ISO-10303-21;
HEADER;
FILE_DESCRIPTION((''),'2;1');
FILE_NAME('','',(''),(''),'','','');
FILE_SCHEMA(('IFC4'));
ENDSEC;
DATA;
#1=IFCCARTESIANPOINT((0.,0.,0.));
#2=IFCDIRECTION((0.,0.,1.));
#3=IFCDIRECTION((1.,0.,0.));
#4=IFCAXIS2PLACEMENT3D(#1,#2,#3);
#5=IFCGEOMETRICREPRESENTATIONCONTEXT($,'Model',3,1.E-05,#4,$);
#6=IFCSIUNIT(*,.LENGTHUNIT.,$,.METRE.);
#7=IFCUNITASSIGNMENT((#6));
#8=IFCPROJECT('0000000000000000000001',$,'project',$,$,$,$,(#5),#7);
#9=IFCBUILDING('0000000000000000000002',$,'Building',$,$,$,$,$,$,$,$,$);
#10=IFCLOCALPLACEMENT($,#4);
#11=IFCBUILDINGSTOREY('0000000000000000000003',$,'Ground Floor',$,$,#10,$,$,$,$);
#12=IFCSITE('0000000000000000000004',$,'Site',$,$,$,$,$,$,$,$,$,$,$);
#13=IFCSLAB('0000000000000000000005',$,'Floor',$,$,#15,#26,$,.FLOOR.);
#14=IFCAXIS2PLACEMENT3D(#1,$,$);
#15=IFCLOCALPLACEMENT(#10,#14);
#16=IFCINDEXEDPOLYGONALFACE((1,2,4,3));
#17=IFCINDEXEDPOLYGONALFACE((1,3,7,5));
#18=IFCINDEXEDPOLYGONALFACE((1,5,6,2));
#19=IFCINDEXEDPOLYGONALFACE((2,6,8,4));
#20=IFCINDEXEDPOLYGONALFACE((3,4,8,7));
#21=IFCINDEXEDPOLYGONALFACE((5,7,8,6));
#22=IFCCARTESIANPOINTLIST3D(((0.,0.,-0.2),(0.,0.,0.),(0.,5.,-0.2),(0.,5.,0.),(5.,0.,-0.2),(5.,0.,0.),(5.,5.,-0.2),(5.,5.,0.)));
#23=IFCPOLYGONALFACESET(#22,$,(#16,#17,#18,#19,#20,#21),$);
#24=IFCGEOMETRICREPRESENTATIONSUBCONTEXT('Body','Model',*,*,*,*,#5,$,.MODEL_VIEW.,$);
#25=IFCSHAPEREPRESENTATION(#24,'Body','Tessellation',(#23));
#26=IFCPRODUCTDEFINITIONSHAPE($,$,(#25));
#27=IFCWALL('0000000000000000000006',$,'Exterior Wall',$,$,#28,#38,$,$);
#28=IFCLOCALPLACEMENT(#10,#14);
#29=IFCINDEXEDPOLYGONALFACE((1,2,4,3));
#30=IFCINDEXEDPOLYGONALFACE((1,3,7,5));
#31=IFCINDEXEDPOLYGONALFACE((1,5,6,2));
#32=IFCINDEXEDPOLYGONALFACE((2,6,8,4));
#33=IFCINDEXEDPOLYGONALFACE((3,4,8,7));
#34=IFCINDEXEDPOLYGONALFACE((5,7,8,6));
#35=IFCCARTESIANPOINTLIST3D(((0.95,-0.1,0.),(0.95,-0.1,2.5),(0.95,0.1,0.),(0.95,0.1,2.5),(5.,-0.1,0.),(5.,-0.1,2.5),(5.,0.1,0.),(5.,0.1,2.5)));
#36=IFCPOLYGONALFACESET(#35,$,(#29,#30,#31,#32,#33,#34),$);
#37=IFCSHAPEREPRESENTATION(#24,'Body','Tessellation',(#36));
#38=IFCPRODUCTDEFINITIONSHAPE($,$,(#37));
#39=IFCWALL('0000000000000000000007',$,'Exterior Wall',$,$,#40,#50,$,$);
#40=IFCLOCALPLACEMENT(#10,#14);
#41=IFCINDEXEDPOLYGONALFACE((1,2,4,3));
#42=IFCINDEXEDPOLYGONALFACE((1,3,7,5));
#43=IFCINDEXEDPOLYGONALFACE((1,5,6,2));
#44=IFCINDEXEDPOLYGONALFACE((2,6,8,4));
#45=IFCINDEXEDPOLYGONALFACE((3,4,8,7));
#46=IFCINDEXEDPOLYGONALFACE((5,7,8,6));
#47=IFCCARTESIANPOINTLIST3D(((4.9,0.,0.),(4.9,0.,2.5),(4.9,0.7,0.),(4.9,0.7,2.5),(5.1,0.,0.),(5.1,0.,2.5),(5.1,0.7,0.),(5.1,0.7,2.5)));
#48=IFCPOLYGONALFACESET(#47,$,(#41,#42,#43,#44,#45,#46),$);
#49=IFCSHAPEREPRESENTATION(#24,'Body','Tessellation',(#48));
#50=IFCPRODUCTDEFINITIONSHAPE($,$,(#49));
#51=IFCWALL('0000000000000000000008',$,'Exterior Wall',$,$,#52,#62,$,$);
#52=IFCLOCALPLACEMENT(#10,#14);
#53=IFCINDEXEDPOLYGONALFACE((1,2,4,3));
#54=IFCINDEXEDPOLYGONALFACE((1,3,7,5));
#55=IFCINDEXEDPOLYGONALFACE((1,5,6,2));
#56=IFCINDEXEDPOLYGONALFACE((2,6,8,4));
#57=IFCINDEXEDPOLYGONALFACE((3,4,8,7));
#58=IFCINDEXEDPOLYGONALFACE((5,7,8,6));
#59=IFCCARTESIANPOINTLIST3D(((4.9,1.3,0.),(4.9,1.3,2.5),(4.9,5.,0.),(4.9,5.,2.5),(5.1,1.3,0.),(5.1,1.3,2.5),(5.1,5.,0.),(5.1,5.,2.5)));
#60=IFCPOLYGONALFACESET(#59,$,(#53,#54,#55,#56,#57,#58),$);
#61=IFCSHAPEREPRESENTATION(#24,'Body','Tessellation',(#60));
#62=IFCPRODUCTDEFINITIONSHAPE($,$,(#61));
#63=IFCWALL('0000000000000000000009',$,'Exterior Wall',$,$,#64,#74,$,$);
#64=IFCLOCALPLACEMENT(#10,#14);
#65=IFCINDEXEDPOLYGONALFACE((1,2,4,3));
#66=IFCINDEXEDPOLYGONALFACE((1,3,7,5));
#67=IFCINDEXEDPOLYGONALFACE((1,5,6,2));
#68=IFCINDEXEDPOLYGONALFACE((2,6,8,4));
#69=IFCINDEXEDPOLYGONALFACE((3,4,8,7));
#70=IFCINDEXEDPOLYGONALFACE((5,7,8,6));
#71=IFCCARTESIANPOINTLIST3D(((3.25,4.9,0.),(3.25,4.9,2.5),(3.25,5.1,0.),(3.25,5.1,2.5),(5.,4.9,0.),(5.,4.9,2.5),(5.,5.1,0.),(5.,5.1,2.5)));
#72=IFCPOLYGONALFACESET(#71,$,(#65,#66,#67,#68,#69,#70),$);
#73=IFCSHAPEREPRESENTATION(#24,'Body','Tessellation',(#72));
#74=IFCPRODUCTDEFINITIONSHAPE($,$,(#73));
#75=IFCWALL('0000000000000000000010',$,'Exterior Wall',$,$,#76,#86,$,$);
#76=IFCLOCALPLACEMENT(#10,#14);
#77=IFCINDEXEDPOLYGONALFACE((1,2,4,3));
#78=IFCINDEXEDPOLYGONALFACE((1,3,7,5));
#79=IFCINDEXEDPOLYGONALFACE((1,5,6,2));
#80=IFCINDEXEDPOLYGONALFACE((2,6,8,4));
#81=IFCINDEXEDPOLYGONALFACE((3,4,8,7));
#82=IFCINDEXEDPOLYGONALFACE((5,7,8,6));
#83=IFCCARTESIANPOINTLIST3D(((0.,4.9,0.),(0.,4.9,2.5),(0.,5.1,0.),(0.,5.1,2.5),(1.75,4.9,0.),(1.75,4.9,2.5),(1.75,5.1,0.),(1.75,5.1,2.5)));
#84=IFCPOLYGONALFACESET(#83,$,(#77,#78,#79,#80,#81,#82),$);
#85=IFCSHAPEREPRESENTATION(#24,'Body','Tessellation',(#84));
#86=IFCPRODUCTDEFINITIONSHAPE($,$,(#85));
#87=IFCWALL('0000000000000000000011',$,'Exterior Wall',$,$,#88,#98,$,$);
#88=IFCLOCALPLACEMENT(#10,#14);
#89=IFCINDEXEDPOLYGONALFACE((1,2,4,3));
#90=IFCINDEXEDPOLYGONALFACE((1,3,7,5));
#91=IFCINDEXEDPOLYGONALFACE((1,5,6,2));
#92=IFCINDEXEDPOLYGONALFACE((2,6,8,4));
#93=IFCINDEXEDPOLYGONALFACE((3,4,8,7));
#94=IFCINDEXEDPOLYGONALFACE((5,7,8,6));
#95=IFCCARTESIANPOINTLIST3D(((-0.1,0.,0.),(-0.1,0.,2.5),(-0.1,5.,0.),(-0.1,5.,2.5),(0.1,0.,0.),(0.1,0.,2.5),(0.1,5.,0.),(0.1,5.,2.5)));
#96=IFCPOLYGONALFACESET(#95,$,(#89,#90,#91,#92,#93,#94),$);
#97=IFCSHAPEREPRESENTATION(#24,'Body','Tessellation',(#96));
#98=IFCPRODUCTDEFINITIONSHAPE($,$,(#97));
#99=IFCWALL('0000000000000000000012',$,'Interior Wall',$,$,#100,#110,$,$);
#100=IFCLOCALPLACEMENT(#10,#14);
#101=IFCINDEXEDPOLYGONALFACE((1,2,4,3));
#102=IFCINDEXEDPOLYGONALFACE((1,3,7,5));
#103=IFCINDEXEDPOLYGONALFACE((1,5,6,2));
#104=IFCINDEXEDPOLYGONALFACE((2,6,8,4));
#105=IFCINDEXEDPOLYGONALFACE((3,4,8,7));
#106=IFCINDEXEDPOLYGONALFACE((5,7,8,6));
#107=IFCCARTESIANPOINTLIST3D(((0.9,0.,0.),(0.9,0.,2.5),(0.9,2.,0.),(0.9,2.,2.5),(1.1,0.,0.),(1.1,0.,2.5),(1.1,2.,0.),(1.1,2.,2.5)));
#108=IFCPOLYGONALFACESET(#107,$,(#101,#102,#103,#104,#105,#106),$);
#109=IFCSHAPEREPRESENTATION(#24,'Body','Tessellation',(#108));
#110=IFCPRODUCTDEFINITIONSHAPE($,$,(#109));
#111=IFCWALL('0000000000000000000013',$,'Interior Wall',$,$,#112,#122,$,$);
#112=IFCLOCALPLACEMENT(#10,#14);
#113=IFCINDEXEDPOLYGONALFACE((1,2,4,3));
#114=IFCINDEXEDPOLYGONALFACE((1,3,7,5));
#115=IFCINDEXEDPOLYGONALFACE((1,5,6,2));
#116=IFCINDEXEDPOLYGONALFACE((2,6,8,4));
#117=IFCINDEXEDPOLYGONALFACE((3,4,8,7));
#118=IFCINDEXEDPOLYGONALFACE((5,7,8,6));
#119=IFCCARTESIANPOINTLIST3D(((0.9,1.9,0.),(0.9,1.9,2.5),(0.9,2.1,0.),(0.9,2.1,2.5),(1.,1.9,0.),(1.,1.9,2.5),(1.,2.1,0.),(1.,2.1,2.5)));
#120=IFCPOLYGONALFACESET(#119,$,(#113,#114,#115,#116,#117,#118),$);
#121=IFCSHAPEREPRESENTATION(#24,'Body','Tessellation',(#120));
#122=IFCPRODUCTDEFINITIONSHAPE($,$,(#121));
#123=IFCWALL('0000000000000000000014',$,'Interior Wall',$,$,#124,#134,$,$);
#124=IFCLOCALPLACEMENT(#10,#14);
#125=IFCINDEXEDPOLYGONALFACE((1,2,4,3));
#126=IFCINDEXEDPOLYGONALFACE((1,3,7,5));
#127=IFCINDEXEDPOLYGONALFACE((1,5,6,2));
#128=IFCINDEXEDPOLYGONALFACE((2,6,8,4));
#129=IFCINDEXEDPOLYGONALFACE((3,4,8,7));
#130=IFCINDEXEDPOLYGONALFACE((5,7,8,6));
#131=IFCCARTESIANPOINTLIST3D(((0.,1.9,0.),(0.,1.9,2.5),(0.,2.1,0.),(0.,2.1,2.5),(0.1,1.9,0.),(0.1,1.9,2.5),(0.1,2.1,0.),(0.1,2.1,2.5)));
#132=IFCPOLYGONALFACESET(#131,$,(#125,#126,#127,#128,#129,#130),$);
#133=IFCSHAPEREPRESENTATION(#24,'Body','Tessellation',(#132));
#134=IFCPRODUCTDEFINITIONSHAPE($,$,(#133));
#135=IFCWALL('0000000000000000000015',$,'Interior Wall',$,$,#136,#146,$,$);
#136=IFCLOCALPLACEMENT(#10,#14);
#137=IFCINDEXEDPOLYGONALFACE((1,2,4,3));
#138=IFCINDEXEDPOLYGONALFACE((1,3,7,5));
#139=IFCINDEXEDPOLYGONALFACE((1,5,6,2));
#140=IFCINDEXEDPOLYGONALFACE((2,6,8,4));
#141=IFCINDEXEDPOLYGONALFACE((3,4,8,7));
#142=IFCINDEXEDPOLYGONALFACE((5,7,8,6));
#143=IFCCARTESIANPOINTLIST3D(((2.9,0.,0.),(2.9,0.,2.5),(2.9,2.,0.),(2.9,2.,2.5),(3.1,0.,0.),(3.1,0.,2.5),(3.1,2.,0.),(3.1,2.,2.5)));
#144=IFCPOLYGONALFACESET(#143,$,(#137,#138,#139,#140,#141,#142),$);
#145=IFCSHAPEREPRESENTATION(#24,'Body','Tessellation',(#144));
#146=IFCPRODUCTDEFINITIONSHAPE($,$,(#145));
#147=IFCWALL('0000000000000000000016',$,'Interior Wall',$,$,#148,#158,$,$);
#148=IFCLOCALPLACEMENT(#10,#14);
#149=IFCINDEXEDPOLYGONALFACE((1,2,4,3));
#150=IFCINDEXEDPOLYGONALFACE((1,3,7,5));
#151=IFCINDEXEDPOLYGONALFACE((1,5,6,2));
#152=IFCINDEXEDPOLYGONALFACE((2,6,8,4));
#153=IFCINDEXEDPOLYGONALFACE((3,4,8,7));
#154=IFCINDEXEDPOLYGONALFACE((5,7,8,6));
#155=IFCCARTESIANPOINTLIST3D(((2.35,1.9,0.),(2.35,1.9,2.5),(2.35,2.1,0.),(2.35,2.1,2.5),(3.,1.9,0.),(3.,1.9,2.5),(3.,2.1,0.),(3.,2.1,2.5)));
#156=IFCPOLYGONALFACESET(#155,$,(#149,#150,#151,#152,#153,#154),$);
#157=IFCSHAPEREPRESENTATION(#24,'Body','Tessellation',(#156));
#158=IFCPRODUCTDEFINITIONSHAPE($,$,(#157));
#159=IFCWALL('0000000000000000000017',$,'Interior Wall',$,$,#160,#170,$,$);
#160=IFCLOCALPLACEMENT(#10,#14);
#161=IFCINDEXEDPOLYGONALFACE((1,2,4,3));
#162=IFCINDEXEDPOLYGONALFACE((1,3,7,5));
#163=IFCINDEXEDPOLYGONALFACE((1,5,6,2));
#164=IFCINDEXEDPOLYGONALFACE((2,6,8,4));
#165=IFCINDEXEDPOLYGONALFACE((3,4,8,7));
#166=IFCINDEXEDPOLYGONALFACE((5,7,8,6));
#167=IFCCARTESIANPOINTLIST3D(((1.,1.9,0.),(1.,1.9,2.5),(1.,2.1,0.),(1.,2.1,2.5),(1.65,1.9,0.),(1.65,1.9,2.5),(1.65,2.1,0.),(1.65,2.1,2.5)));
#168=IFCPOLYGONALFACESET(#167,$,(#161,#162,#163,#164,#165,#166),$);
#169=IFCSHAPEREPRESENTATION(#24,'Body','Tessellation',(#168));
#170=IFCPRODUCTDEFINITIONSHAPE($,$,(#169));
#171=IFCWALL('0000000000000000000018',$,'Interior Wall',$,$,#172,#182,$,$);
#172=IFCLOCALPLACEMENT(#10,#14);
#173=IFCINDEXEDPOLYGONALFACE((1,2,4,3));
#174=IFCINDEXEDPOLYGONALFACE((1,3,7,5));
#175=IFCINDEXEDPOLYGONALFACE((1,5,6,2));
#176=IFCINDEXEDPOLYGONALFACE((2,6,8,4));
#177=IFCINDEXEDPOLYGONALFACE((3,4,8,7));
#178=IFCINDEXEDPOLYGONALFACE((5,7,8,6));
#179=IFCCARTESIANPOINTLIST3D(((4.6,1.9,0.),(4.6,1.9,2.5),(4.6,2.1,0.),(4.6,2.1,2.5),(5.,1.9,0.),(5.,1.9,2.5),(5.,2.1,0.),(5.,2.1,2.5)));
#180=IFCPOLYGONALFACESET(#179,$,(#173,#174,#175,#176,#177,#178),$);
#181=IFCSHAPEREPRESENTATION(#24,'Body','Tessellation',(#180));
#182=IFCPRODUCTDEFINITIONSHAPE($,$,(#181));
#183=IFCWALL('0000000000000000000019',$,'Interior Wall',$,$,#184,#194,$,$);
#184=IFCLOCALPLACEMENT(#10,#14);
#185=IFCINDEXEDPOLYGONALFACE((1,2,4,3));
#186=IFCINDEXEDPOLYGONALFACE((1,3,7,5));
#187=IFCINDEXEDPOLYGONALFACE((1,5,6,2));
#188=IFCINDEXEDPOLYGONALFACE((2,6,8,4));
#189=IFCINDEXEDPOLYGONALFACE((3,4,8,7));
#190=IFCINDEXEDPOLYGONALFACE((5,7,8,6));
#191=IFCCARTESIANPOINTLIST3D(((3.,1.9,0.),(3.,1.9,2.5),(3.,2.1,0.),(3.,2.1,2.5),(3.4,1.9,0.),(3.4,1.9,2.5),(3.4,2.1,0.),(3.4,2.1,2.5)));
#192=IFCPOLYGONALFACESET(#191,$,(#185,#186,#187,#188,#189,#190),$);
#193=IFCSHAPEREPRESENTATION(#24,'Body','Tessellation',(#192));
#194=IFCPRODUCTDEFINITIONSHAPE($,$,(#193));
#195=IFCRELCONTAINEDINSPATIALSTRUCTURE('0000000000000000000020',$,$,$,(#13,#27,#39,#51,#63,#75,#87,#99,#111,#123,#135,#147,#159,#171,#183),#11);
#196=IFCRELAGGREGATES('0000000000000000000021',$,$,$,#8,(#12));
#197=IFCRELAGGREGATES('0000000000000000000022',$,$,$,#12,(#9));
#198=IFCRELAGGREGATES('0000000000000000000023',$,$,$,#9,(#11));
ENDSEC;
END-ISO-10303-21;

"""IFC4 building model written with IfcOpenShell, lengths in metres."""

from ifc_helpers import new_model, si_unit, frame, origin_with_axes, place, context, subcontext, project, spatial, indexed_curve, outline, extrude, element, save


model = new_model("IFC4")

# Units and contexts
model_context = context("Model", 3, precision=1e-05, world=origin_with_axes())
body_context = subcontext(model_context, "Body", "Model", "MODEL_VIEW")
ifc_project = project(units=[si_unit("LENGTHUNIT", "METRE")], contexts=[model_context])

# Site, building, storey
site = spatial("IfcSite", under=ifc_project, Name="Site")
building = spatial("IfcBuilding", under=site, Name="Building")
storey_placement = place(None, origin_with_axes())
storey = spatial("IfcBuildingStorey", under=building, at=storey_placement, Name="Ground Floor")

# Slab
slab_placement = place(storey_placement, frame((0.0, 0.0, -0.2), z_axis=(0.0, 0.0, 1.0), x_axis=(1.0, 0.0, 0.0)))
element("IfcSlab", 1, at=slab_placement, inside=storey, Name="Floor", PredefinedType="FLOOR", context=body_context, shape_type="SweptSolid", body=[
    extrude(outline(indexed_curve([(0.0, 0.0), (5.0, 0.0), (5.0, 5.0), (0.0, 5.0)])), None, (0.0, 0.0, 1.0), 0.2),
])

# Walls
wall_1_placement = place(storey_placement, frame((0.95, 0.0, 0.0), z_axis=(0.0, 0.0, 1.0), x_axis=(1.0, 0.0, 0.0)))
element("IfcWall", 2, at=wall_1_placement, inside=storey, Name="Exterior Wall", context=body_context, shape_type="SweptSolid", body=[
    extrude(outline(indexed_curve([(0.0, 0.0), (0.0, 0.2), (4.05, 0.2), (4.05, 0.0), (0.0, 0.0)], self_intersect=False)), frame((0.0, -0.1, 0.0), z_axis=(0.0, 0.0, 1.0), x_axis=(1.0, 0.0, 0.0)), (0.0, 0.0, 1.0), 2.5),
])
wall_2_placement = place(storey_placement, frame((5.0, 0.0, 0.0), z_axis=(0.0, 0.0, 1.0), x_axis=(0.0, 1.0, 0.0)))
element("IfcWall", 3, at=wall_2_placement, inside=storey, Name="Exterior Wall", context=body_context, shape_type="SweptSolid", body=[
    extrude(outline(indexed_curve([(0.0, 0.0), (0.0, 0.2), (0.7, 0.2), (0.7, 0.0), (0.0, 0.0)], self_intersect=False)), frame((0.0, -0.1, 0.0), z_axis=(0.0, 0.0, 1.0), x_axis=(1.0, 0.0, 0.0)), (0.0, 0.0, 1.0), 2.5),
])
wall_3_placement = place(storey_placement, frame((5.0, 1.3, 0.0), z_axis=(0.0, 0.0, 1.0), x_axis=(0.0, 1.0, 0.0)))
element("IfcWall", 4, at=wall_3_placement, inside=storey, Name="Exterior Wall", context=body_context, shape_type="SweptSolid", body=[
    extrude(outline(indexed_curve([(0.0, 0.0), (0.0, 0.2), (3.7, 0.2), (3.7, 0.0), (0.0, 0.0)], self_intersect=False)), frame((0.0, -0.1, 0.0), z_axis=(0.0, 0.0, 1.0), x_axis=(1.0, 0.0, 0.0)), (0.0, 0.0, 1.0), 2.5),
])
for number, where, z_axis, x_axis, name in (
    (5, (5.0, 5.0, 0.0), (0.0, 0.0, 1.0), (-1.0, 0.0, 0.0), "Exterior Wall"),
    (6, (1.75, 5.0, 0.0), (0.0, 0.0, 1.0), (-1.0, 0.0, 0.0), "Exterior Wall"),
):
    element("IfcWall", number, at=place(storey_placement, frame(where, z_axis=z_axis, x_axis=x_axis)), inside=storey, Name=name, context=body_context, shape_type="SweptSolid", body=[
        extrude(outline(indexed_curve([(0.0, 0.0), (0.0, 0.2), (1.75, 0.2), (1.75, 0.0), (0.0, 0.0)], self_intersect=False)), frame((0.0, -0.1, 0.0), z_axis=(0.0, 0.0, 1.0), x_axis=(1.0, 0.0, 0.0)), (0.0, 0.0, 1.0), 2.5),
    ])
wall_4_placement = place(storey_placement, frame((0.0, 5.0, 0.0), z_axis=(0.0, 0.0, 1.0), x_axis=(0.0, -1.0, 0.0)))
element("IfcWall", 7, at=wall_4_placement, inside=storey, Name="Exterior Wall", context=body_context, shape_type="SweptSolid", body=[
    extrude(outline(indexed_curve([(0.0, 0.0), (0.0, 0.2), (5.0, 0.2), (5.0, 0.0), (0.0, 0.0)], self_intersect=False)), frame((0.0, -0.1, 0.0), z_axis=(0.0, 0.0, 1.0), x_axis=(1.0, 0.0, 0.0)), (0.0, 0.0, 1.0), 2.5),
])
wall_5_placement = place(storey_placement, frame((1.0, 0.0, 0.0), z_axis=(0.0, 0.0, 1.0), x_axis=(0.0, 1.0, 0.0)))
element("IfcWall", 8, at=wall_5_placement, inside=storey, Name="Interior Wall", context=body_context, shape_type="SweptSolid", body=[
    extrude(outline(indexed_curve([(0.0, 0.0), (0.0, 0.2), (2.0, 0.2), (2.0, 0.0), (0.0, 0.0)], self_intersect=False)), frame((0.0, -0.1, 0.0), z_axis=(0.0, 0.0, 1.0), x_axis=(1.0, 0.0, 0.0)), (0.0, 0.0, 1.0), 2.5),
])
for number, where, z_axis, x_axis, name in (
    (9, (1.0, 2.0, 0.0), (0.0, 0.0, 1.0), (-1.0, 0.0, 0.0), "Interior Wall"),
    (10, (0.1, 2.0, 0.0), (0.0, 0.0, 1.0), (-1.0, 0.0, 0.0), "Interior Wall"),
):
    element("IfcWall", number, at=place(storey_placement, frame(where, z_axis=z_axis, x_axis=x_axis)), inside=storey, Name=name, context=body_context, shape_type="SweptSolid", body=[
        extrude(outline(indexed_curve([(0.0, 0.0), (0.0, 0.2), (0.1, 0.2), (0.1, 0.0), (0.0, 0.0)], self_intersect=False)), frame((0.0, -0.1, 0.0), z_axis=(0.0, 0.0, 1.0), x_axis=(1.0, 0.0, 0.0)), (0.0, 0.0, 1.0), 2.5),
    ])
wall_6_placement = place(storey_placement, frame((3.0, 0.0, 0.0), z_axis=(0.0, 0.0, 1.0), x_axis=(0.0, 1.0, 0.0)))
element("IfcWall", 11, at=wall_6_placement, inside=storey, Name="Interior Wall", context=body_context, shape_type="SweptSolid", body=[
    extrude(outline(indexed_curve([(0.0, 0.0), (0.0, 0.2), (2.0, 0.2), (2.0, 0.0), (0.0, 0.0)], self_intersect=False)), frame((0.0, -0.1, 0.0), z_axis=(0.0, 0.0, 1.0), x_axis=(1.0, 0.0, 0.0)), (0.0, 0.0, 1.0), 2.5),
])
for number, where, z_axis, x_axis, name in (
    (12, (3.0, 2.0, 0.0), (0.0, 0.0, 1.0), (-1.0, 0.0, 0.0), "Interior Wall"),
    (13, (1.65, 2.0, 0.0), (0.0, 0.0, 1.0), (-1.0, 0.0, 0.0), "Interior Wall"),
):
    element("IfcWall", number, at=place(storey_placement, frame(where, z_axis=z_axis, x_axis=x_axis)), inside=storey, Name=name, context=body_context, shape_type="SweptSolid", body=[
        extrude(outline(indexed_curve([(0.0, 0.0), (0.0, 0.2), (0.65, 0.2), (0.65, 0.0), (0.0, 0.0)], self_intersect=False)), frame((0.0, -0.1, 0.0), z_axis=(0.0, 0.0, 1.0), x_axis=(1.0, 0.0, 0.0)), (0.0, 0.0, 1.0), 2.5),
    ])
wall_7_placement = place(storey_placement, frame((5.0, 2.0, 0.0), z_axis=(0.0, 0.0, 1.0), x_axis=(-1.0, 0.0, 0.0)))
element("IfcWall", 14, at=wall_7_placement, inside=storey, Name="Interior Wall", context=body_context, shape_type="SweptSolid", body=[
    extrude(outline(indexed_curve([(0.0, 0.0), (0.0, 0.2), (0.4, 0.2), (0.4, 0.0), (0.0, 0.0)], self_intersect=False)), frame((0.0, -0.1, 0.0), z_axis=(0.0, 0.0, 1.0), x_axis=(1.0, 0.0, 0.0)), (0.0, 0.0, 1.0), 2.5),
])
wall_8_placement = place(storey_placement, frame((3.4, 2.0, 0.0), z_axis=(0.0, 0.0, 1.0), x_axis=(-1.0, 0.0, 0.0)))
element("IfcWall", 15, at=wall_8_placement, inside=storey, Name="Interior Wall", context=body_context, shape_type="SweptSolid", body=[
    extrude(outline(indexed_curve([(0.0, 0.0), (0.0, 0.2), (0.4, 0.2), (0.4, 0.0), (0.0, 0.0)], self_intersect=False)), frame((0.0, -0.1, 0.0), z_axis=(0.0, 0.0, 1.0), x_axis=(1.0, 0.0, 0.0)), (0.0, 0.0, 1.0), 2.5),
])

save(model, "model.ifc")
